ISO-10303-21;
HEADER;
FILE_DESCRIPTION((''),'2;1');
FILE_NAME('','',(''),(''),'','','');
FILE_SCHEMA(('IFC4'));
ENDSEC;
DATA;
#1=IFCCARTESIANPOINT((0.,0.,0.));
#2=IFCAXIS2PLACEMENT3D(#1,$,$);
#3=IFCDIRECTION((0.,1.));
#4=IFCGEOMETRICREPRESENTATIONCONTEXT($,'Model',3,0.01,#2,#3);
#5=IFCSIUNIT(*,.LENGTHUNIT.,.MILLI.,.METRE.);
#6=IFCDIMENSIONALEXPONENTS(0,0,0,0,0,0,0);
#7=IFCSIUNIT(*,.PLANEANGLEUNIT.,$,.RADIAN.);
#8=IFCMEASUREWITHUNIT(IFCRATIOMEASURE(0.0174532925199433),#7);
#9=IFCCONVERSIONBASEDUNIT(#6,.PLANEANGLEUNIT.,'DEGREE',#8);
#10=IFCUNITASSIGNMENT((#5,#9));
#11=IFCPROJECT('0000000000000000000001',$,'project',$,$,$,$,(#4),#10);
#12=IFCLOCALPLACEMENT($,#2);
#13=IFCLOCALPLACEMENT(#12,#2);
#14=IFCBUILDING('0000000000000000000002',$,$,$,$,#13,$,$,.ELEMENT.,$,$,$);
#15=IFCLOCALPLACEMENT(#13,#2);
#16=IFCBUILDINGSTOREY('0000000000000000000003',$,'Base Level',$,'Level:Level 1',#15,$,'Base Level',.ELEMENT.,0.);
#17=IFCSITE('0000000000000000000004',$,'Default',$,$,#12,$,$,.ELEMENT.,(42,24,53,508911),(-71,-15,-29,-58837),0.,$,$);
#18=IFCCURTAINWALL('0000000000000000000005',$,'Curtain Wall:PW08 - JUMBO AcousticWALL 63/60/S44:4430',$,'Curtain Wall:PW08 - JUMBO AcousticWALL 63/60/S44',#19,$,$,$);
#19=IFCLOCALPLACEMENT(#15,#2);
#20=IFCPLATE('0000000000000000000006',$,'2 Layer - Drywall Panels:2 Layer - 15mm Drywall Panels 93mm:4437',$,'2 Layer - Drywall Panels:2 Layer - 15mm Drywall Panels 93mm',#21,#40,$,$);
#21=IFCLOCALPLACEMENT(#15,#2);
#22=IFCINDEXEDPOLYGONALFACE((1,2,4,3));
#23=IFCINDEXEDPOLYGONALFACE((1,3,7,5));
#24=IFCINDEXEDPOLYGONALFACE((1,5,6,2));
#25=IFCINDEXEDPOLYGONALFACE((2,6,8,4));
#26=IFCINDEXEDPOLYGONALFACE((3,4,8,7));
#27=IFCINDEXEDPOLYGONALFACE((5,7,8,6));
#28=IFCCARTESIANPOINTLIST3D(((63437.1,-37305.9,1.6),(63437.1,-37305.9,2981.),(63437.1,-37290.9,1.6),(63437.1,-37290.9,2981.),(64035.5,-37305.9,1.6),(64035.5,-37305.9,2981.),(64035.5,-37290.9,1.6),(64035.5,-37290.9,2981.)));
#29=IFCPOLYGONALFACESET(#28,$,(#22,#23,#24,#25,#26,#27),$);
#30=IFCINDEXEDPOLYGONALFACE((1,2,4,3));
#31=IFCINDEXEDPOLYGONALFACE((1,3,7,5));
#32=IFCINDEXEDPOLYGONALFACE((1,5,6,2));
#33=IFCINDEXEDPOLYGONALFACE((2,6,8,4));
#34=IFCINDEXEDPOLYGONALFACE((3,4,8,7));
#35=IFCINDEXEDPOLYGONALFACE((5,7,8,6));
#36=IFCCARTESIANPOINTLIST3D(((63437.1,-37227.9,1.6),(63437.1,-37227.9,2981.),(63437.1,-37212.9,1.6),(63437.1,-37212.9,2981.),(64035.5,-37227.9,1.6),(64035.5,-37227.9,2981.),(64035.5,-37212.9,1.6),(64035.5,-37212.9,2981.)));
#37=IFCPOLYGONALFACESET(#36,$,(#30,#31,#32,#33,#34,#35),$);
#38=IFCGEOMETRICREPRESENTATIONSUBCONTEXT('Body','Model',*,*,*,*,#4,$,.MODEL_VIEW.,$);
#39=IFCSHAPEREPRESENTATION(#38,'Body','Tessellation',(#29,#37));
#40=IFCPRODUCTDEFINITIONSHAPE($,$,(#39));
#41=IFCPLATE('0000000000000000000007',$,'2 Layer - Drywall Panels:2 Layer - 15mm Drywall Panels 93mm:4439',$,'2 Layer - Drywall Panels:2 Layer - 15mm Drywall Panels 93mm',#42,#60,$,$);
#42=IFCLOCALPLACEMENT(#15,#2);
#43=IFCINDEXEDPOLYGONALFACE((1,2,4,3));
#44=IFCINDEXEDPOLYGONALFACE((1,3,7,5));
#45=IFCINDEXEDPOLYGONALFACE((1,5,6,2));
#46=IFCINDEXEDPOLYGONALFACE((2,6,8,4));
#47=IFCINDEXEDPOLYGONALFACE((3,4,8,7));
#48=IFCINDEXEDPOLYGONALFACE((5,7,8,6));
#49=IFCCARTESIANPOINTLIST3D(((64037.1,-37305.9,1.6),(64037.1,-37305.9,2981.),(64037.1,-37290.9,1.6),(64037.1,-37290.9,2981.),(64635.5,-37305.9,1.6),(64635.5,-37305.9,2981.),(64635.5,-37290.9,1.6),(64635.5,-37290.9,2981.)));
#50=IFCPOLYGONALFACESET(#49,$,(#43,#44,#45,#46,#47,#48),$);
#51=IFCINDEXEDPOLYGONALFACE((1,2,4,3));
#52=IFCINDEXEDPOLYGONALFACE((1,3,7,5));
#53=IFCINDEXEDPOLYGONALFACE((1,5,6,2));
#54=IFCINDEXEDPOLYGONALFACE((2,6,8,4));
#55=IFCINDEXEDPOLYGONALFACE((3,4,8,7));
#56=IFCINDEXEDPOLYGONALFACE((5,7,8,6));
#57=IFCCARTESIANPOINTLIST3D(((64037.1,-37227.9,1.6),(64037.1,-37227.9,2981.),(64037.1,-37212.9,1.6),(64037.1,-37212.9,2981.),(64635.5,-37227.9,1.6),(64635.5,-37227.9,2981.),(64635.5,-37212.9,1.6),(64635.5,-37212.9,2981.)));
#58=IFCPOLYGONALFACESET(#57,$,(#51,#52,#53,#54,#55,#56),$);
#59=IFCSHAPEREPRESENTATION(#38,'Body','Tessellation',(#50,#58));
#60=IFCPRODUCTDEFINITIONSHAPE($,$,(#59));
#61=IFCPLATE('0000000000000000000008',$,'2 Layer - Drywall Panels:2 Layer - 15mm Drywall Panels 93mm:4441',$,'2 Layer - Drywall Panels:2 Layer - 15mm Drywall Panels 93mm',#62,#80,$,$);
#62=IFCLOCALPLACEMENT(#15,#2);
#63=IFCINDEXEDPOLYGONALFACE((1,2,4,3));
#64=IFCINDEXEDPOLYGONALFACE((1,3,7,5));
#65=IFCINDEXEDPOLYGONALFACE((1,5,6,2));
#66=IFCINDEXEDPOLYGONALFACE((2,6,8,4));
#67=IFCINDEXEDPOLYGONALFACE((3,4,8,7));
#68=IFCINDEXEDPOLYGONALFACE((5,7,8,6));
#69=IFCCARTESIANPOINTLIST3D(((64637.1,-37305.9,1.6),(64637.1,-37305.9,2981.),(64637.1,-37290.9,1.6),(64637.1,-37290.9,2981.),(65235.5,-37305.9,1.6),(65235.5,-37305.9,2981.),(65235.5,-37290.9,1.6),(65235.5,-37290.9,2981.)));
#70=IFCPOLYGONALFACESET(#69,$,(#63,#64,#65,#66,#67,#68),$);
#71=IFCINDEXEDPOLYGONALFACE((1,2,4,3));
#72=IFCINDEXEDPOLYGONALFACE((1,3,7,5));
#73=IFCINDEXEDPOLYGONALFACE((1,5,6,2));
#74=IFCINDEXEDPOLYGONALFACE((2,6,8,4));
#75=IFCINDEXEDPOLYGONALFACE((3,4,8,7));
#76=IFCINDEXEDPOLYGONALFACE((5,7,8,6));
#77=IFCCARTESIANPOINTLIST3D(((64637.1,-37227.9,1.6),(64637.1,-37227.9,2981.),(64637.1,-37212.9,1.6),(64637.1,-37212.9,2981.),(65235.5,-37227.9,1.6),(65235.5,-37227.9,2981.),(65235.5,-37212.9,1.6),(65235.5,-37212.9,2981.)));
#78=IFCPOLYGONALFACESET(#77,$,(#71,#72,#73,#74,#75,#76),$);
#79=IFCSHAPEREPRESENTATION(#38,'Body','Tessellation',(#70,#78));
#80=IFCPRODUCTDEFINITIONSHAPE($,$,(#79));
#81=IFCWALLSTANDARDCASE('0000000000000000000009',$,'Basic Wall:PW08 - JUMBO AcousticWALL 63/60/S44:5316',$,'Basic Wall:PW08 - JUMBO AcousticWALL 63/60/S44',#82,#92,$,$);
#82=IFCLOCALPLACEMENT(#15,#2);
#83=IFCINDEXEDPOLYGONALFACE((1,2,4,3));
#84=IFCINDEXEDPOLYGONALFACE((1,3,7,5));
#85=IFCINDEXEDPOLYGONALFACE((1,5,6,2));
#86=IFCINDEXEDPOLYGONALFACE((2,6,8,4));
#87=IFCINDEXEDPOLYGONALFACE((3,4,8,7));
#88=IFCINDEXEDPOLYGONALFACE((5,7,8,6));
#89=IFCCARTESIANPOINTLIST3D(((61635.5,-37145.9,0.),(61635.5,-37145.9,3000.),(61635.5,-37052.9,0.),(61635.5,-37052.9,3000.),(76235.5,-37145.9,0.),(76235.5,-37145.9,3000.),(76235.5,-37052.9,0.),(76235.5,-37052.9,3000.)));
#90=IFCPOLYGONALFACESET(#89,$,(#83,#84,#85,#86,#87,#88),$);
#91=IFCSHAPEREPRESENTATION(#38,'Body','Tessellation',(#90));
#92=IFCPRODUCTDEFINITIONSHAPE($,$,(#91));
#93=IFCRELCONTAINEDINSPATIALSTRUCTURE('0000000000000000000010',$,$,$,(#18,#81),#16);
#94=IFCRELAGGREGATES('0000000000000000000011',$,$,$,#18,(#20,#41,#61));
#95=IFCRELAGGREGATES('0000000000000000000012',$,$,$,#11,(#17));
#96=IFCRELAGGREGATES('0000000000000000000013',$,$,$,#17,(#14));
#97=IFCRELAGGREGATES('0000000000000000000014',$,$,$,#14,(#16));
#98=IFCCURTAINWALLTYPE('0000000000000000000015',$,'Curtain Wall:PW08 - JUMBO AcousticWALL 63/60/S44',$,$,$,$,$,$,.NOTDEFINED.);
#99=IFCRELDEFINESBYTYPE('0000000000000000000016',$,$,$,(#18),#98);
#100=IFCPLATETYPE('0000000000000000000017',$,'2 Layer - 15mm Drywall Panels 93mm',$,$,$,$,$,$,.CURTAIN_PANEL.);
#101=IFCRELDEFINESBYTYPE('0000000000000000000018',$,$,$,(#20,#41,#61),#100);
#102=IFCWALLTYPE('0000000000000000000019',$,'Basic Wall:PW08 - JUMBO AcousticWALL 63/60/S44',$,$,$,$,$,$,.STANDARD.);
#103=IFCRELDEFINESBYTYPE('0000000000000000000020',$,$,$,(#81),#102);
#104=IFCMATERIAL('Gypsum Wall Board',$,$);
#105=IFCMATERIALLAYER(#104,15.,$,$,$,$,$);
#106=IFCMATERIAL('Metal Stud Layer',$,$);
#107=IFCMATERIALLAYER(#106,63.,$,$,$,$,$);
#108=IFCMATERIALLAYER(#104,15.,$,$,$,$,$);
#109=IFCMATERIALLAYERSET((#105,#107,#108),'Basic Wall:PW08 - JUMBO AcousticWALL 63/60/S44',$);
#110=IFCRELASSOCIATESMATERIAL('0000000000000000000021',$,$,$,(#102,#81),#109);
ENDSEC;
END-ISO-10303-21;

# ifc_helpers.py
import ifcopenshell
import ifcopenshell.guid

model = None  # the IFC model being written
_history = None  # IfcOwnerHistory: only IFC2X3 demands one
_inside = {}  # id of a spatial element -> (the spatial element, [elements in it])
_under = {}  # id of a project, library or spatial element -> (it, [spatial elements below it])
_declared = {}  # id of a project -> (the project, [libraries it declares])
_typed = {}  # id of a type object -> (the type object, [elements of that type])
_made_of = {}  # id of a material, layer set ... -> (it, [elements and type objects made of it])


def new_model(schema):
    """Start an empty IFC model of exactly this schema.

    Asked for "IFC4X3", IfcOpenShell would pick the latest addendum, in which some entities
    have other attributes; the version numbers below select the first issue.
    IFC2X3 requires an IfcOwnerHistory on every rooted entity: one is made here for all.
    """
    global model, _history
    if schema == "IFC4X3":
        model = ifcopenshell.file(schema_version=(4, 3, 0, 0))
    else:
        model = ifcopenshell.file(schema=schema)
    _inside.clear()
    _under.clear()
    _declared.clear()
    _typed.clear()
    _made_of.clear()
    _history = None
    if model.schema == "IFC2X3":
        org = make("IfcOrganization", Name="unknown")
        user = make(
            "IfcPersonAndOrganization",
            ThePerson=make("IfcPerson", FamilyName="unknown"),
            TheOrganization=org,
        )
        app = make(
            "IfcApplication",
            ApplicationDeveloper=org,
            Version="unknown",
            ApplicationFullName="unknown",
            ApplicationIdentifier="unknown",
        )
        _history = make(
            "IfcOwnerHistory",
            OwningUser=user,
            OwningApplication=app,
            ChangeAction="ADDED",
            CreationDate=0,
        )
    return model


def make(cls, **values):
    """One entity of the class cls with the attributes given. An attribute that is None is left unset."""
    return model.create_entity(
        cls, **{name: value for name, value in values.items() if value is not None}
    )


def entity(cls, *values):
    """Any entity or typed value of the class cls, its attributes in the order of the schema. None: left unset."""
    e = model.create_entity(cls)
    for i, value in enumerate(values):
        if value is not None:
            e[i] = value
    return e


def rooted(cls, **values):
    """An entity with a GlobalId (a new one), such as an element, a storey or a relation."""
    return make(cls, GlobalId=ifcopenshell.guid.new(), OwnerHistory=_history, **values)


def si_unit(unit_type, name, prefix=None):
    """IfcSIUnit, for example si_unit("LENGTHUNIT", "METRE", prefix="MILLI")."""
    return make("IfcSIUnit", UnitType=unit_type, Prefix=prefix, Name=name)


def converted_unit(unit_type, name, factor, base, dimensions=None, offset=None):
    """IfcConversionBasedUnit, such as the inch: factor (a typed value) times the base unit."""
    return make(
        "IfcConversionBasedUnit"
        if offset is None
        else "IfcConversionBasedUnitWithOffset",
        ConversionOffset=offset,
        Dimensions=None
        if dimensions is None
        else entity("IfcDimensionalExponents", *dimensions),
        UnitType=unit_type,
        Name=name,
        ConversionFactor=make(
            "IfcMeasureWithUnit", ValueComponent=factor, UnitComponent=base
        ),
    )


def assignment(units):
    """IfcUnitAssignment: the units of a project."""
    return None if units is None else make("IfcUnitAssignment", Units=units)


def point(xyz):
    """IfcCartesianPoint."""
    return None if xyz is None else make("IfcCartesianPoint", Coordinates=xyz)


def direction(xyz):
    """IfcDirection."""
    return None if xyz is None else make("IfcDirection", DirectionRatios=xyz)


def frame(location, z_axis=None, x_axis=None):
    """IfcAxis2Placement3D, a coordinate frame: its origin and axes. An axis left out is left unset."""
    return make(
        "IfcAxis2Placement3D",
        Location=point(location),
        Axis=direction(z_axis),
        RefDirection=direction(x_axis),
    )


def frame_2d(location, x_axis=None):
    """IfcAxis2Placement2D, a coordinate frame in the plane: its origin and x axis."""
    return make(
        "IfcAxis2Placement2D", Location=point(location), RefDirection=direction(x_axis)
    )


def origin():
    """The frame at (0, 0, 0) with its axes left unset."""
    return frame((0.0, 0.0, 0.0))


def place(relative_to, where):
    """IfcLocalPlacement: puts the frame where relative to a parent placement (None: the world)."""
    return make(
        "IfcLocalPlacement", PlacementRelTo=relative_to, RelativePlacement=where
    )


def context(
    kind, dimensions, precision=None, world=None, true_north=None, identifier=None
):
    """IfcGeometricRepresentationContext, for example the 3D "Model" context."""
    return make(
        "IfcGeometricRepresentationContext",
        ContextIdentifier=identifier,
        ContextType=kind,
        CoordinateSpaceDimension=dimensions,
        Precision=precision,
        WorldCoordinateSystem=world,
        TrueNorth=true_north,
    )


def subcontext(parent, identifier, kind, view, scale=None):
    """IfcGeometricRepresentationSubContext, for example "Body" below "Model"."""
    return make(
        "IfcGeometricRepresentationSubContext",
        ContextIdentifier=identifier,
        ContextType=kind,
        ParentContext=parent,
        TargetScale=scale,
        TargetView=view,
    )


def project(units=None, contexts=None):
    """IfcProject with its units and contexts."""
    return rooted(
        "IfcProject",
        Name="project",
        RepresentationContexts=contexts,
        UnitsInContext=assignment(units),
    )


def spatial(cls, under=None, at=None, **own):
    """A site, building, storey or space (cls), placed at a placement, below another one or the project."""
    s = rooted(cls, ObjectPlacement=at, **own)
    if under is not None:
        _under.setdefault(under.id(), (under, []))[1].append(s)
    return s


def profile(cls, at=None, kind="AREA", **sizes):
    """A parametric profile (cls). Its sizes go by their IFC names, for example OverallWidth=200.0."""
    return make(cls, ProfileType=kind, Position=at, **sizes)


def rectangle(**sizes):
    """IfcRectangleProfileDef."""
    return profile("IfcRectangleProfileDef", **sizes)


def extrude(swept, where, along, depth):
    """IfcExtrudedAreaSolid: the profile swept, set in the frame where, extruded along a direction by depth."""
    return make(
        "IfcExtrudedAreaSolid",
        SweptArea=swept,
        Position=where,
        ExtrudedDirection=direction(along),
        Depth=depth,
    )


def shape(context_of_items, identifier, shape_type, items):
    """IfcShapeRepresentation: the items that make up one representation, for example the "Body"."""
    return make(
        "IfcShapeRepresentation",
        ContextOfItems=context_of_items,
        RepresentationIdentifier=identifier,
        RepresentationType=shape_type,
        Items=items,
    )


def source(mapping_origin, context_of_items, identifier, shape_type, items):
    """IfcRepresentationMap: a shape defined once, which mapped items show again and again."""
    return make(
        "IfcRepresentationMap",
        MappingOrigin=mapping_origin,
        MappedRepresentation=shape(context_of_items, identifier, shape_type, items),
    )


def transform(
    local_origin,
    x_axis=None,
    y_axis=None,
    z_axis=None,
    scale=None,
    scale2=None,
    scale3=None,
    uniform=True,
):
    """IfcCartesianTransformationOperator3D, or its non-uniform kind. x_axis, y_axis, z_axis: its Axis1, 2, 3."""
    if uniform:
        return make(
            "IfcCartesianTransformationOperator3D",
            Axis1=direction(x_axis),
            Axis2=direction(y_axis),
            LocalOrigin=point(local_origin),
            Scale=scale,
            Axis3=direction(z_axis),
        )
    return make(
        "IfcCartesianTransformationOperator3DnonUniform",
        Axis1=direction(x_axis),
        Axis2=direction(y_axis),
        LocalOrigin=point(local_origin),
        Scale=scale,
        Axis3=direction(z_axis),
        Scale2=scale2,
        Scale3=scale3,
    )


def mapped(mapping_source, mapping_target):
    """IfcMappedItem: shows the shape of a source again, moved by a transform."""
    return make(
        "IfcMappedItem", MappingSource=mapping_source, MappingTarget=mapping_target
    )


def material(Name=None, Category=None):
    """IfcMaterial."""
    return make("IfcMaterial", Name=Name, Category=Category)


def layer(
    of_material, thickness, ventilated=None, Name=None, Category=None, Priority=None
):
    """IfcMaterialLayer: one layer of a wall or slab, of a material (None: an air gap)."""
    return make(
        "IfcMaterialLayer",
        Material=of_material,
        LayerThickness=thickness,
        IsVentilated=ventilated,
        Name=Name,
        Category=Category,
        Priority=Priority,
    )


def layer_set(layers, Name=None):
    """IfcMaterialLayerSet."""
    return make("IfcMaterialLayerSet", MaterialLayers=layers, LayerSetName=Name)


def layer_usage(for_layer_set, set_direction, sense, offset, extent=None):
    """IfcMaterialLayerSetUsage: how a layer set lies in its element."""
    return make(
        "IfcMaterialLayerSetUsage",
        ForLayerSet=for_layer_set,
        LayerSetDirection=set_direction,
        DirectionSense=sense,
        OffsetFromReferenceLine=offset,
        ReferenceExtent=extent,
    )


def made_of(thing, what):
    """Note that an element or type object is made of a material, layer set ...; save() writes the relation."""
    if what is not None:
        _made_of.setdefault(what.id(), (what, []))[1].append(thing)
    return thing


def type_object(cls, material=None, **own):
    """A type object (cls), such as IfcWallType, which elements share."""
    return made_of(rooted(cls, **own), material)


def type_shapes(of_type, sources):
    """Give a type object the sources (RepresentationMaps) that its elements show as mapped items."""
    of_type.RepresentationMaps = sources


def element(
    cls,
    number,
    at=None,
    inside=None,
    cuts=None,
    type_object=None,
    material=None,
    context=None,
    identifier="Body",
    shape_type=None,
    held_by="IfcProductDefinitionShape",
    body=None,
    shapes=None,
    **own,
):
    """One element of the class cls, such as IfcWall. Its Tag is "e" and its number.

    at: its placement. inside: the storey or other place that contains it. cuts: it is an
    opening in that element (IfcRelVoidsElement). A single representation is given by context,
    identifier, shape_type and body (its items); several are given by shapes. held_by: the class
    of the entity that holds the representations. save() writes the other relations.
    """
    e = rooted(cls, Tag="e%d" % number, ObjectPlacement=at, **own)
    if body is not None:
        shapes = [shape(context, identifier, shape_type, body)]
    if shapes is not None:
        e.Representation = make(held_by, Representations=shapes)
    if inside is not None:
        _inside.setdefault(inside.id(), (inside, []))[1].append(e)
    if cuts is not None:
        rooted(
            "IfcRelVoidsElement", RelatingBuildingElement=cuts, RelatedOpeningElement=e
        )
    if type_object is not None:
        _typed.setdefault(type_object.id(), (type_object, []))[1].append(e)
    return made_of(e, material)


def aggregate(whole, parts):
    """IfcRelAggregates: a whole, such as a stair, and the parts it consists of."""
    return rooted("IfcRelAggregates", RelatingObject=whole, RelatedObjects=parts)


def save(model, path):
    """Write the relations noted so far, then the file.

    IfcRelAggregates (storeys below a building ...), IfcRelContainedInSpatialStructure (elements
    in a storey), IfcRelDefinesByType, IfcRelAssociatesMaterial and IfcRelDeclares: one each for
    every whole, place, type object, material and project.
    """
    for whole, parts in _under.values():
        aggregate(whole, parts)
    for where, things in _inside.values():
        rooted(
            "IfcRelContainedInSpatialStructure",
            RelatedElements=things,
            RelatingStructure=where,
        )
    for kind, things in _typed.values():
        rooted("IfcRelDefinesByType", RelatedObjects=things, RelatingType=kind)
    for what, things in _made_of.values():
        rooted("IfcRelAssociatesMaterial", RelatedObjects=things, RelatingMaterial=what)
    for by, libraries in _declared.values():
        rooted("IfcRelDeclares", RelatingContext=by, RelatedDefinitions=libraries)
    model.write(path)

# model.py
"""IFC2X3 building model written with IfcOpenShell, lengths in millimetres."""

from ifc_helpers import new_model, entity, si_unit, converted_unit, direction, frame, frame_2d, origin, place, context, subcontext, project, spatial, rectangle, extrude, source, transform, mapped, material, layer, layer_set, layer_usage, type_object, type_shapes, element, aggregate, save


model = new_model("IFC2X3")

# Units and contexts
model_context = context("Model", 3, precision=0.01, world=origin(), true_north=direction((0.0, 1.0)))
body_context = subcontext(model_context, "Body", "Model", "MODEL_VIEW")
ifc_project = project(units=[si_unit("LENGTHUNIT", "METRE", prefix="MILLI"), converted_unit("PLANEANGLEUNIT", "DEGREE", entity("IfcRatioMeasure", 0.0174532925199433), si_unit("PLANEANGLEUNIT", "RADIAN"), dimensions=[0, 0, 0, 0, 0, 0, 0])], contexts=[model_context])

# Site, building, storey
site_placement = place(None, origin())
site = spatial("IfcSite", under=ifc_project, at=site_placement, Name="Default", CompositionType="ELEMENT", RefLatitude=(42, 24, 53, 508911), RefLongitude=(-71, -15, -29, -58837), RefElevation=0.0)
building_placement = place(site_placement, origin())
building = spatial("IfcBuilding", under=site, at=building_placement, CompositionType="ELEMENT")
storey_placement = place(building_placement, origin())
storey = spatial("IfcBuildingStorey", under=building, at=storey_placement, Name="Base Level", ObjectType="Level:Level 1", LongName="Base Level", CompositionType="ELEMENT", Elevation=0.0)

# Curtain wall, plates
curtain_wall_type = type_object("IfcCurtainWallType", Name="Curtain Wall:PW08 - JUMBO AcousticWALL 63/60/S44", PredefinedType="NOTDEFINED")
curtain_wall_placement = place(building_placement, origin())
curtain_wall = element("IfcCurtainWall", 1, at=curtain_wall_placement, inside=storey, type_object=curtain_wall_type, Name="Curtain Wall:PW08 - JUMBO AcousticWALL 63/60/S44:4430", ObjectType="Curtain Wall:PW08 - JUMBO AcousticWALL 63/60/S44")
plate_type = type_object("IfcPlateType", Name="2 Layer - 15mm Drywall Panels 93mm", PredefinedType="CURTAIN_PANEL")
shared_shape_1 = source(origin(), body_context, "Body", "SweptSolid", [
    extrude(rectangle(XDim=598.4, YDim=15.0, at=frame_2d((0.0, 0.0), x_axis=(1.0, 0.0))), frame((0.0, -39.0, 0.0), z_axis=(0.0, 0.0, 1.0), x_axis=(-1.0, 0.0, 0.0)), (0.0, 0.0, 1.0), 2979.4),
    extrude(rectangle(XDim=15.0, YDim=598.4, at=frame_2d((0.0, 0.0), x_axis=(1.0, 0.0))), frame((0.0, 39.0, 0.0), z_axis=(0.0, 0.0, 1.0), x_axis=(0.0, 1.0, 0.0)), (0.0, 0.0, 1.0), 2979.4),
])
type_shapes(plate_type, [shared_shape_1])
plate_1_placement = place(curtain_wall_placement, frame((63736.3, -37259.4, 1.6)))
plate_1 = element("IfcPlate", 2, at=plate_1_placement, type_object=plate_type, Name="2 Layer - Drywall Panels:2 Layer - 15mm Drywall Panels 93mm:4437", ObjectType="2 Layer - Drywall Panels:2 Layer - 15mm Drywall Panels 93mm", context=body_context, shape_type="MappedRepresentation", body=[
    mapped(shared_shape_1, transform((0.0, 0.0, 0.0), scale=1.0)),
])
plate_2_placement = place(curtain_wall_placement, frame((64336.3, -37259.4, 1.6)))
plate_2 = element("IfcPlate", 3, at=plate_2_placement, type_object=plate_type, Name="2 Layer - Drywall Panels:2 Layer - 15mm Drywall Panels 93mm:4439", ObjectType="2 Layer - Drywall Panels:2 Layer - 15mm Drywall Panels 93mm", context=body_context, shape_type="MappedRepresentation", body=[
    mapped(shared_shape_1, transform((0.0, 0.0, 0.0), scale=1.0)),
])
plate_3_placement = place(curtain_wall_placement, frame((64936.3, -37259.4, 1.6)))
plate_3 = element("IfcPlate", 4, at=plate_3_placement, type_object=plate_type, Name="2 Layer - Drywall Panels:2 Layer - 15mm Drywall Panels 93mm:4441", ObjectType="2 Layer - Drywall Panels:2 Layer - 15mm Drywall Panels 93mm", context=body_context, shape_type="MappedRepresentation", body=[
    mapped(shared_shape_1, transform((0.0, 0.0, 0.0), scale=1.0)),
])
aggregate(curtain_wall, [plate_1, plate_2, plate_3])

# Wall
ifc_material_1 = material(Name="Gypsum Wall Board")
ifc_layer_1 = layer(ifc_material_1, 15.0)
ifc_material_2 = material(Name="Metal Stud Layer")
ifc_layer_2 = layer(ifc_material_2, 63.0)
ifc_layer_3 = layer(ifc_material_1, 15.0)
ifc_layer_set = layer_set([ifc_layer_1, ifc_layer_2, ifc_layer_3], Name="Basic Wall:PW08 - JUMBO AcousticWALL 63/60/S44")
ifc_layer_usage = layer_usage(ifc_layer_set, "AXIS2", "NEGATIVE", 46.5)
wall_type = type_object("IfcWallType", Name="Basic Wall:PW08 - JUMBO AcousticWALL 63/60/S44", PredefinedType="STANDARD", material=ifc_layer_set)
wall_placement = place(building_placement, frame((61635.5, -37099.4, 0.0)))
element("IfcWallStandardCase", 5, at=wall_placement, inside=storey, type_object=wall_type, material=ifc_layer_usage, Name="Basic Wall:PW08 - JUMBO AcousticWALL 63/60/S44:5316", ObjectType="Basic Wall:PW08 - JUMBO AcousticWALL 63/60/S44", context=body_context, shape_type="SweptSolid", body=[
    extrude(rectangle(XDim=14600.0, YDim=93.0, at=frame_2d((7300.0, 0.0), x_axis=(-1.0, 0.0))), origin(), (0.0, 0.0, 1.0), 3000.0),
])

save(model, "model.ifc")
